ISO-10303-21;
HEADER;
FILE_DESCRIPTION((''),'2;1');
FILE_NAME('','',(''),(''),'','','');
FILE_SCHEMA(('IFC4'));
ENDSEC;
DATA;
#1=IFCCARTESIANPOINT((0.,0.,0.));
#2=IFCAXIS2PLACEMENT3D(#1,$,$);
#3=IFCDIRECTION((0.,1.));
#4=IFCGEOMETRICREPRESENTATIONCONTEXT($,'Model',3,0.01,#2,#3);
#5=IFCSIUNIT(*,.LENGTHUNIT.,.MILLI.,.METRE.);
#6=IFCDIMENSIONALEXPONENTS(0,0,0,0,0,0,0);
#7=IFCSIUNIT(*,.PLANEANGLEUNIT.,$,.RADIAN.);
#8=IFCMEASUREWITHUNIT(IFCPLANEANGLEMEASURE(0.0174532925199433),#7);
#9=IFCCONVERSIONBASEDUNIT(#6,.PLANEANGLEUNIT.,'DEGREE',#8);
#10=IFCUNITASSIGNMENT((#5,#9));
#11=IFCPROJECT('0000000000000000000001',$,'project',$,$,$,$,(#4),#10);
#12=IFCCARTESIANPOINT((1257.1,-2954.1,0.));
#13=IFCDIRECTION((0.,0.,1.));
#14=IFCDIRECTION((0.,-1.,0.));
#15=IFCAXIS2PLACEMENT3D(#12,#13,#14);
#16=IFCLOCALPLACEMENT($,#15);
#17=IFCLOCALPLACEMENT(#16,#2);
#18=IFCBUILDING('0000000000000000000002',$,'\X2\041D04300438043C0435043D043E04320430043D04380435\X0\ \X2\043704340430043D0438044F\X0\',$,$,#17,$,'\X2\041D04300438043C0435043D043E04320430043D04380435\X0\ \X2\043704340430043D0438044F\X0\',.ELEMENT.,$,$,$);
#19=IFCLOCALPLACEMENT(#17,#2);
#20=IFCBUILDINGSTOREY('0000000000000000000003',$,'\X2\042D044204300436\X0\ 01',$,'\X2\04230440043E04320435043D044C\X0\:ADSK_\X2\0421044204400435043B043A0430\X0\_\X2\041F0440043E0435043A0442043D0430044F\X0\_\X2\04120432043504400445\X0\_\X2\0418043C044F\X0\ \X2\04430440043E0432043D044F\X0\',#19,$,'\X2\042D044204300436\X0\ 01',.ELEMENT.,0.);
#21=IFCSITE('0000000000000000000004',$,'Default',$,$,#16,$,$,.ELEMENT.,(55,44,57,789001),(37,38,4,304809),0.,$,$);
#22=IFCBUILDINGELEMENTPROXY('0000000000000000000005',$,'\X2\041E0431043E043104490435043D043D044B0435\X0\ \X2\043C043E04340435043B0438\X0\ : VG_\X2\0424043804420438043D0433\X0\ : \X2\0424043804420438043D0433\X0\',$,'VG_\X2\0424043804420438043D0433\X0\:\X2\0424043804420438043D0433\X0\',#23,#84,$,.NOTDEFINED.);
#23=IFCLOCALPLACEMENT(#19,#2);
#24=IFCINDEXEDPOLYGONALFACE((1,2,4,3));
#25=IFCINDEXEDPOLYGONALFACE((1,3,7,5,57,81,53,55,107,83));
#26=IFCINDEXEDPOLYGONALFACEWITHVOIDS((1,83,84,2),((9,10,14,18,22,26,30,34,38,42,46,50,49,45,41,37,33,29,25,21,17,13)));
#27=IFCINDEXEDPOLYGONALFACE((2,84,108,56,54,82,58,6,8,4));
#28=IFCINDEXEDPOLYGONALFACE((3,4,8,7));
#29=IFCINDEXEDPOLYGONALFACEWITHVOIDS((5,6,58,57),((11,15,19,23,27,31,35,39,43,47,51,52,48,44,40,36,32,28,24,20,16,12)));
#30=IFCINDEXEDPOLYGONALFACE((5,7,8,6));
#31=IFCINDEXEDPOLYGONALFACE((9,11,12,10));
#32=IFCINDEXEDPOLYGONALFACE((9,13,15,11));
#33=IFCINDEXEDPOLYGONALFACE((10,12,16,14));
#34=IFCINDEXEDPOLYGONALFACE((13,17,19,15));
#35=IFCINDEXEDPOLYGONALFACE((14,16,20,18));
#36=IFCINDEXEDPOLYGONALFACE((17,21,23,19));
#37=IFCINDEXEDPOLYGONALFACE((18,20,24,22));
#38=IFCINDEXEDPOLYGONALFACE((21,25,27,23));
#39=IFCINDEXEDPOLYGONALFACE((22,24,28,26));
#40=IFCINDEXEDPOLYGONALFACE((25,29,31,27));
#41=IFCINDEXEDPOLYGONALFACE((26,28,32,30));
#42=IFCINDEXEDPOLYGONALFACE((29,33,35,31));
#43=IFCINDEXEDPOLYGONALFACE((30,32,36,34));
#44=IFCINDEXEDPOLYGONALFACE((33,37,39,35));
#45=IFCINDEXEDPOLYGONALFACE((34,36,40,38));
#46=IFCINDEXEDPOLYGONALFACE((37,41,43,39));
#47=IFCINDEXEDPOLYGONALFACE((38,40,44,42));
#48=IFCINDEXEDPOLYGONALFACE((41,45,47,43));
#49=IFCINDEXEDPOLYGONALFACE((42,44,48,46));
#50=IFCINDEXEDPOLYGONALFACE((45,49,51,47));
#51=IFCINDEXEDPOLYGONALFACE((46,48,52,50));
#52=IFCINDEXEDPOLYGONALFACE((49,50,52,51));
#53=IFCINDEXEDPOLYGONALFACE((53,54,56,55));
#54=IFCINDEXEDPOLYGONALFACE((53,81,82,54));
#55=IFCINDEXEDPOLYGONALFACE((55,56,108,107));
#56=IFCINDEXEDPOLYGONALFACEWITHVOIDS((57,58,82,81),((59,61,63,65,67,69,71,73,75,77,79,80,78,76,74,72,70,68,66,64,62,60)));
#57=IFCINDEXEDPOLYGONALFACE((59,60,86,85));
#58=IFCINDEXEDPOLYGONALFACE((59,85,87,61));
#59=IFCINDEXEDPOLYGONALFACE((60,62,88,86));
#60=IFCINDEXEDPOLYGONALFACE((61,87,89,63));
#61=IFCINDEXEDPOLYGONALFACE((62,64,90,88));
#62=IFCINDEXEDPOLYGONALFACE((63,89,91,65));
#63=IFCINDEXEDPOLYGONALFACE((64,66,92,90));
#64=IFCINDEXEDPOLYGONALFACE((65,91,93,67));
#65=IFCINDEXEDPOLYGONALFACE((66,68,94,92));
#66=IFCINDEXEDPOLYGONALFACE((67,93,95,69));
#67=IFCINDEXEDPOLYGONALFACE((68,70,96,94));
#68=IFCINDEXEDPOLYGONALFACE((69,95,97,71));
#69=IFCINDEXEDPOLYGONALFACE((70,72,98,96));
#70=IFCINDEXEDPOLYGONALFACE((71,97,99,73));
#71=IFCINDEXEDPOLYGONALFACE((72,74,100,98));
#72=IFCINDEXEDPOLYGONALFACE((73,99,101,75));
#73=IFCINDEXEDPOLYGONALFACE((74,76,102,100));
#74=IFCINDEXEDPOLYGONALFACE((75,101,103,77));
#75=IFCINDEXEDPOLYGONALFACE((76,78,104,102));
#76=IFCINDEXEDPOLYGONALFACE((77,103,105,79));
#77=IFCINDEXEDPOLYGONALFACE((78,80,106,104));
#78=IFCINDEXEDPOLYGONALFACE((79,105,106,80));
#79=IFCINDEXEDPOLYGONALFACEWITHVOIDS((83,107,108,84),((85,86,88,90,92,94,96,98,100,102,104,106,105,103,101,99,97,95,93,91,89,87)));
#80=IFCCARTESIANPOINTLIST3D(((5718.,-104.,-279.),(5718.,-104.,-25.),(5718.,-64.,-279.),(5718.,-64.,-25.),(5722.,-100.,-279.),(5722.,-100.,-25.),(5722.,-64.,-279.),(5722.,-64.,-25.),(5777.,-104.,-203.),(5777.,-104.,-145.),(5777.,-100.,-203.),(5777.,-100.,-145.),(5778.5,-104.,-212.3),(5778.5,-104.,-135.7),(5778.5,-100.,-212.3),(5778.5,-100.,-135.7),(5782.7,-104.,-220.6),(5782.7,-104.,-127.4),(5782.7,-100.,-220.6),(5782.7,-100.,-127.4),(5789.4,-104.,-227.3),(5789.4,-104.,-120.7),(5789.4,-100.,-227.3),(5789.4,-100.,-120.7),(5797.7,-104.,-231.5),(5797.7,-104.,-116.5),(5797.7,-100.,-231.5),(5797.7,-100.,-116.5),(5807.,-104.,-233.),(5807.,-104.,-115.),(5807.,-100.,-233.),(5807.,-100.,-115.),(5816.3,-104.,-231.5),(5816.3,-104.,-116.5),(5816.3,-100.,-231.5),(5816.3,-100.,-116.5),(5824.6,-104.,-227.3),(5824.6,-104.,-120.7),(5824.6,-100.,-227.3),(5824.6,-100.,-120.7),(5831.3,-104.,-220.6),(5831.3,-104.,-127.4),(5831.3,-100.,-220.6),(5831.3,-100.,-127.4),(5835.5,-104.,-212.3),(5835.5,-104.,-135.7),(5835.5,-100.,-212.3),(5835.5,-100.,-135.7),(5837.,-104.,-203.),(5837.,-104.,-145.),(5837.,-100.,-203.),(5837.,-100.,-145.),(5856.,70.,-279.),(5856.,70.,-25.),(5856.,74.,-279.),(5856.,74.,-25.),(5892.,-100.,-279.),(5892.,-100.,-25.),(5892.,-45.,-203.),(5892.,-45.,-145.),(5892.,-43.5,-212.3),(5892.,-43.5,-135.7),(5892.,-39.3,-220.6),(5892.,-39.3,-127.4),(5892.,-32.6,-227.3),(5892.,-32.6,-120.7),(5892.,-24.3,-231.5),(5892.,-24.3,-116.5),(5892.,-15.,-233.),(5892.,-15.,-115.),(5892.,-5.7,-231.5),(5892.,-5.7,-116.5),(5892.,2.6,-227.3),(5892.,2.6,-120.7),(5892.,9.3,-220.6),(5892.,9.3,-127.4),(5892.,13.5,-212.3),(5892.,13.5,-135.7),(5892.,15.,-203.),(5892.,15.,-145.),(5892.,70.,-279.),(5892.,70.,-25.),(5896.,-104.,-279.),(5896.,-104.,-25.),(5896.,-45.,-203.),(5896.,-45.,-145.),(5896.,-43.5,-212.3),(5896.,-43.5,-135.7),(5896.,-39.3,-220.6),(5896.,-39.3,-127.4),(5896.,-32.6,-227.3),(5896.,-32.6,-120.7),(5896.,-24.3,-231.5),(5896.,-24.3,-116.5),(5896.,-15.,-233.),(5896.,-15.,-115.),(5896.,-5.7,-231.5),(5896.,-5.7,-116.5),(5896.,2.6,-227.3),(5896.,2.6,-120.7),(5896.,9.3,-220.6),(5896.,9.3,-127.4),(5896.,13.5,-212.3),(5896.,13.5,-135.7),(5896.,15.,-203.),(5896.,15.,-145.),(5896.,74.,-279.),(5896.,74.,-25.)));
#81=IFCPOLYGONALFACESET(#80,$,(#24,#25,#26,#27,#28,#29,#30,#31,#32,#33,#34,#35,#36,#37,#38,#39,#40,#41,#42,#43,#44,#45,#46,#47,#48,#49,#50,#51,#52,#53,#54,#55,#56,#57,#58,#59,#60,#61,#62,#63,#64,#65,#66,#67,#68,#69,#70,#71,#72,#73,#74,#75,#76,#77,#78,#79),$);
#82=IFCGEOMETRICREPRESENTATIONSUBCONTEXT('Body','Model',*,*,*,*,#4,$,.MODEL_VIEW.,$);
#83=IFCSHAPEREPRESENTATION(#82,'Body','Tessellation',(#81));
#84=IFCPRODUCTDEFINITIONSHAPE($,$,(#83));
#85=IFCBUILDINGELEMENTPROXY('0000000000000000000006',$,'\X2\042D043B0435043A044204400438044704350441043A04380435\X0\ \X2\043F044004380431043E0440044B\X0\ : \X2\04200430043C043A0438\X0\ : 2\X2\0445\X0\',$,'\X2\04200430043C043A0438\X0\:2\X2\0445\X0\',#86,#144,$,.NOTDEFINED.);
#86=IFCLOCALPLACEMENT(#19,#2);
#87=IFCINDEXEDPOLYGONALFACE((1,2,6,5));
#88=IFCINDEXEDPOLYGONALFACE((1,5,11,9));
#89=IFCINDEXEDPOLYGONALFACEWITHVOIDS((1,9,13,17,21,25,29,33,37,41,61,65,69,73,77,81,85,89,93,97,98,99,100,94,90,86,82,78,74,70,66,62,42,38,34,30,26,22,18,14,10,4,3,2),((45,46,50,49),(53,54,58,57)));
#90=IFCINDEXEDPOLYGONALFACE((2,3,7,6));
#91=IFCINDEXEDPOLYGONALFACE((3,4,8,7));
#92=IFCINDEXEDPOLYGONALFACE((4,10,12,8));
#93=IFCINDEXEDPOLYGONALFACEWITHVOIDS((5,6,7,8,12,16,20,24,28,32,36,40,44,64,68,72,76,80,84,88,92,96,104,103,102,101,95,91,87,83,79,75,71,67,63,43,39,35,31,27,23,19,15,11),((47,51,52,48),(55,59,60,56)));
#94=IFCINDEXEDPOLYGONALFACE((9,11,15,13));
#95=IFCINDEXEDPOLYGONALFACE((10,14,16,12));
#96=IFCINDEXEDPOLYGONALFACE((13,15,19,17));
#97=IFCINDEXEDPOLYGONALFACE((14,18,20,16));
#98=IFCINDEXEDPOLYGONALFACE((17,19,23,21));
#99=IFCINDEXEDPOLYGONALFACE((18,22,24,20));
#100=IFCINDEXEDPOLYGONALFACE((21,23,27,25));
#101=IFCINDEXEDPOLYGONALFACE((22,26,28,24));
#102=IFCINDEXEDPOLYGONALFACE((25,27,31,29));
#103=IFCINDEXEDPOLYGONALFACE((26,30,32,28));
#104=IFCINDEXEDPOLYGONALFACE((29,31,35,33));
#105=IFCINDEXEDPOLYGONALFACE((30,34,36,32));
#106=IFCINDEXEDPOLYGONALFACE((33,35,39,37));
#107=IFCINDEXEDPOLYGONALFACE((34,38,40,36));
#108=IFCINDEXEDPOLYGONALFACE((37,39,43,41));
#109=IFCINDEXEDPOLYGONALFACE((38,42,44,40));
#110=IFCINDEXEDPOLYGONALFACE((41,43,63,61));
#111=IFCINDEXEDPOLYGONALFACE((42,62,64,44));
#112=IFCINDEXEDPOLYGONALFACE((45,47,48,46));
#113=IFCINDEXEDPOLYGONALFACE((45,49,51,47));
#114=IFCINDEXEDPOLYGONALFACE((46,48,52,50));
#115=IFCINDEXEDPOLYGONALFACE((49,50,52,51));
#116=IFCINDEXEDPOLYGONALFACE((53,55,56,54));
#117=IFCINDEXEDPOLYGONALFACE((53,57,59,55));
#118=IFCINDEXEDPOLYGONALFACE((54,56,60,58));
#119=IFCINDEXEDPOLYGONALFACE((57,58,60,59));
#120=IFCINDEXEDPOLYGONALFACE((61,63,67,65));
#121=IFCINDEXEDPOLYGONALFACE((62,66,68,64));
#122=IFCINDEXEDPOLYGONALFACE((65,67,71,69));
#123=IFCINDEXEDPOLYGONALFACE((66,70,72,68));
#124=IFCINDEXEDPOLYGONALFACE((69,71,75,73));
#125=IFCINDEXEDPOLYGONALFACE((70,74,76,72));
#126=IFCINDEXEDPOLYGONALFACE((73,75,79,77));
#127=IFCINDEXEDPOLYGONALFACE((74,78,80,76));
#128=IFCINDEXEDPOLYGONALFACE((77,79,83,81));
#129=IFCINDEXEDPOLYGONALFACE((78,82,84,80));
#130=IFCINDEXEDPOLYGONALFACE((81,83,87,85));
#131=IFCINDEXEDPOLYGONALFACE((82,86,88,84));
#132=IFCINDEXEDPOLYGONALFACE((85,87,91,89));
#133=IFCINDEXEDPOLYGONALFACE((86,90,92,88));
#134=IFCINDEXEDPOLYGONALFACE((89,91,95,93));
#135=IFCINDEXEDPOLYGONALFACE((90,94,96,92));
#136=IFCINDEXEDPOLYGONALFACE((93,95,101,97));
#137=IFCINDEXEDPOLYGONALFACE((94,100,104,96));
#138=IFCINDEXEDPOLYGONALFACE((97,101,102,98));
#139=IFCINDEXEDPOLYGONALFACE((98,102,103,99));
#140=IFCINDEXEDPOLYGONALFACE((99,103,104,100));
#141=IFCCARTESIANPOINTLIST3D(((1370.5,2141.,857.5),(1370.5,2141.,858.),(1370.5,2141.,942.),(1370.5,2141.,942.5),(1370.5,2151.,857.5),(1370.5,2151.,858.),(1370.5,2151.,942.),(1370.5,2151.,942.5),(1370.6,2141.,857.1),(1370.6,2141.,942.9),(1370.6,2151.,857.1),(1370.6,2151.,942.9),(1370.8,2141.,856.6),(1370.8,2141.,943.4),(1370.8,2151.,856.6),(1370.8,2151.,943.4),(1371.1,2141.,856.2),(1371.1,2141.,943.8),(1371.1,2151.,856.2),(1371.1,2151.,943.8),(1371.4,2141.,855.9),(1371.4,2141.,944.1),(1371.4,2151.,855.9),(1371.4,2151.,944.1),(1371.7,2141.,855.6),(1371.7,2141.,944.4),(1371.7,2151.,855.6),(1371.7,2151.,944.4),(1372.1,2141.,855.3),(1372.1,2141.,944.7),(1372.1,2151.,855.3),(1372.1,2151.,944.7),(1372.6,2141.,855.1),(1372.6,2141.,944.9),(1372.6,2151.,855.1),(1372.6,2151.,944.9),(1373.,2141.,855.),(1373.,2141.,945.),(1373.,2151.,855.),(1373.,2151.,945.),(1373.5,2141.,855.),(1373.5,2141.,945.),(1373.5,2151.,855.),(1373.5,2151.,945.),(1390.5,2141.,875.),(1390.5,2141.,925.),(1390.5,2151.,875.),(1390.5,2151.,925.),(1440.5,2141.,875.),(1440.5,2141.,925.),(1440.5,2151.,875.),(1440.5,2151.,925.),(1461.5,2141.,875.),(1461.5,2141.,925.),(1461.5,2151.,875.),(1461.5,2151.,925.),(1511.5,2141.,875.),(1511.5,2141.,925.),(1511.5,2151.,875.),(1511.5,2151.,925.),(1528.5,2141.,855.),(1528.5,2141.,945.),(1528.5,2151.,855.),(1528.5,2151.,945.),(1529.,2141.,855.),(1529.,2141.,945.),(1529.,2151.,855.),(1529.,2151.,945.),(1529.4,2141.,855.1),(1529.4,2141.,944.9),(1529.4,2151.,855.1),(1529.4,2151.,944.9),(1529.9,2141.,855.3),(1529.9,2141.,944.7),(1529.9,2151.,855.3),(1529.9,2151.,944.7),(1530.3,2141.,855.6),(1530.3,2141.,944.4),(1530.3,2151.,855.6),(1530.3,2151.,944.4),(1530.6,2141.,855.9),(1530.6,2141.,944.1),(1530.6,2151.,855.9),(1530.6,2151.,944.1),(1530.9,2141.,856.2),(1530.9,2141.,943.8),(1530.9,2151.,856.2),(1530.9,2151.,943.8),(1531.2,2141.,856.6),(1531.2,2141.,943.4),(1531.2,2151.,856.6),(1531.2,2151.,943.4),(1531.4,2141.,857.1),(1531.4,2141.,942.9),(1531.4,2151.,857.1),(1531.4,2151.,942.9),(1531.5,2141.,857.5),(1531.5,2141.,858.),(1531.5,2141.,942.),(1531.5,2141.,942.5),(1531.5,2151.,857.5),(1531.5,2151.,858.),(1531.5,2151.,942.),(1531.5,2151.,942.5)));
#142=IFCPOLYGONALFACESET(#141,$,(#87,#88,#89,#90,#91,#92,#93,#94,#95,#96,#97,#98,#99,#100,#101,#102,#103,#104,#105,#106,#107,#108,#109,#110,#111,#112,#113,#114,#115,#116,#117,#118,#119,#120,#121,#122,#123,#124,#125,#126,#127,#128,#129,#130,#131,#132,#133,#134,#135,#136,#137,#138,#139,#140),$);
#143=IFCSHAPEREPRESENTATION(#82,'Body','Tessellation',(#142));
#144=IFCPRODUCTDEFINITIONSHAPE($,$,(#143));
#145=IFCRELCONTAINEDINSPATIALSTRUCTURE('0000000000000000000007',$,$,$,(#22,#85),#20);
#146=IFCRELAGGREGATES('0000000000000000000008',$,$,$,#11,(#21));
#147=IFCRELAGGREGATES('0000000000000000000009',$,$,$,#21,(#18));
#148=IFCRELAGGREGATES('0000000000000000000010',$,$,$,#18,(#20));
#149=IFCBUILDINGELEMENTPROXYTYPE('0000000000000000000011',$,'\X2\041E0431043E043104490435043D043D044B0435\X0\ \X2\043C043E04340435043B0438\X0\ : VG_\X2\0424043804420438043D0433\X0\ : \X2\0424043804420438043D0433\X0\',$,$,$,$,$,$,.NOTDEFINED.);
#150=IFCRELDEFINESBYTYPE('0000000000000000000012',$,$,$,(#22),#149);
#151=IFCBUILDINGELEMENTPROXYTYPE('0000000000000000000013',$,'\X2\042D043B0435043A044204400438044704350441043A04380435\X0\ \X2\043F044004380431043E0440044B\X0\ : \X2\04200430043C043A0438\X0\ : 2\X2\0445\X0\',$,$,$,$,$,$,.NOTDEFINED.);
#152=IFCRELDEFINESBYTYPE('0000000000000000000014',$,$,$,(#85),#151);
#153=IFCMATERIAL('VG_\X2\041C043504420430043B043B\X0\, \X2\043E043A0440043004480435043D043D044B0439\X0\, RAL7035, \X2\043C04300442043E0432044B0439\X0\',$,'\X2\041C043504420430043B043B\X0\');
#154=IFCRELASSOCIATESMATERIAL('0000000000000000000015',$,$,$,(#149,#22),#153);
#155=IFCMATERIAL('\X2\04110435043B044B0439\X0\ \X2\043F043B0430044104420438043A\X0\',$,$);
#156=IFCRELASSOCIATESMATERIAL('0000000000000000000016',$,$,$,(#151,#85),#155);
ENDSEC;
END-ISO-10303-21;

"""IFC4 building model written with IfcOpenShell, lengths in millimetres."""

from ifc_helpers import new_model, entity, si_unit, converted_unit, direction, frame, origin, place, context, subcontext, project, spatial, indexed_curve, outline, extrude, source, transform, mapped, material, type_object, type_shapes, element, save


model = new_model("IFC4")

# Units and contexts
model_context = context("Model", 3, precision=0.01, world=origin(), true_north=direction((0.0, 1.0)))
body_context = subcontext(model_context, "Body", "Model", "MODEL_VIEW")
ifc_project = project(units=[si_unit("LENGTHUNIT", "METRE", prefix="MILLI"), converted_unit("PLANEANGLEUNIT", "DEGREE", entity("IfcPlaneAngleMeasure", 0.0174532925199433), si_unit("PLANEANGLEUNIT", "RADIAN"), dimensions=[0, 0, 0, 0, 0, 0, 0])], contexts=[model_context])

# Site, building, storey
site_placement = place(None, frame((1257.1, -2954.1, 0.0), z_axis=(0.0, 0.0, 1.0), x_axis=(0.0, -1.0, 0.0)))
site = spatial("IfcSite", under=ifc_project, at=site_placement, Name="Default", CompositionType="ELEMENT", RefLatitude=(55, 44, 57, 789001), RefLongitude=(37, 38, 4, 304809), RefElevation=0.0)
building_placement = place(site_placement, origin())
building = spatial("IfcBuilding", under=site, at=building_placement, Name="Наименование здания", LongName="Наименование здания", CompositionType="ELEMENT")
storey_placement = place(building_placement, origin())
storey = spatial("IfcBuildingStorey", under=building, at=storey_placement, Name="Этаж 01", ObjectType="Уровень:ADSK_Стрелка_Проектная_Вверх_Имя уровня", LongName="Этаж 01", CompositionType="ELEMENT", Elevation=0.0)

# Building element proxy, openings
ifc_material_1 = material(Name="VG_Металл, окрашенный, RAL7035, матовый", Category="Металл")
building_element_proxy_type_1 = type_object("IfcBuildingElementProxyType", Name="Обобщенные модели : VG_Фитинг : Фитинг", PredefinedType="NOTDEFINED", material=ifc_material_1)
shared_shape_1 = source(origin(), body_context, "Body", "SweptSolid", [
    extrude(outline(indexed_curve([(-79.2, -79.2), (98.8, -79.2), (98.8, -39.2), (94.8, -39.2), (94.8, -75.2), (-75.2, -75.2), (-75.2, 94.8), (-39.2, 94.8), (-39.2, 98.8), (-79.2, 98.8), (-79.2, -79.2)], self_intersect=False)), frame((-9.8, -9.8, -279.0)), (0.0, 0.0, 1.0), 254.0),
])
type_shapes(building_element_proxy_type_1, [shared_shape_1])
proxy_1_placement = place(storey_placement, frame((5807.0, -15.0, 0.0), z_axis=(0.0, 0.0, 1.0), x_axis=(0.0, 1.0, 0.0)))
proxy_1 = element("IfcBuildingElementProxy", 1, at=proxy_1_placement, inside=storey, type_object=building_element_proxy_type_1, material=ifc_material_1, Name="Обобщенные модели : VG_Фитинг : Фитинг", ObjectType="VG_Фитинг:Фитинг", PredefinedType="NOTDEFINED", context=body_context, shape_type="MappedRepresentation", body=[
    mapped(shared_shape_1, transform((0.0, 0.0, 0.0), scale=1.0)),
])
opening_1_placement = place(storey_placement, frame((5807.0, -15.0, 0.0), z_axis=(0.0, 0.0, 1.0), x_axis=(-1.0, 0.0, 0.0)))
element("IfcOpeningElement", 2, at=opening_1_placement, cuts=proxy_1, PredefinedType="OPENING", context=body_context, shape_type="SweptSolid", body=[
    extrude(outline(indexed_curve([(-30.0, -29.0), (-28.5, -38.3), (-24.3, -46.6), (-17.6, -53.3), (-9.3, -57.5), (0.0, -59.0), (9.3, -57.5), (17.6, -53.3), (24.3, -46.6), (28.5, -38.3), (30.0, -29.0), (30.0, 29.0), (28.5, 38.3), (24.3, 46.6), (17.6, 53.3), (9.3, 57.5), (0.0, 59.0), (-9.3, 57.5), (-17.6, 53.3), (-24.3, 46.6), (-28.5, 38.3), (-30.0, 29.0), (-30.0, -29.0)], self_intersect=False)), frame((0.0, 89.0, -174.0), z_axis=(0.0, -1.0, 0.0), x_axis=(-1.0, 0.0, 0.0)), (0.0, 0.0, 1.0), 4.0),
])
opening_2_placement = place(storey_placement, frame((5807.0, -15.0, 0.0), z_axis=(0.0, 0.0, 1.0), x_axis=(-1.0, 0.0, 0.0)))
element("IfcOpeningElement", 3, at=opening_2_placement, cuts=proxy_1, PredefinedType="OPENING", context=body_context, shape_type="SweptSolid", body=[
    extrude(outline(indexed_curve([(-30.0, -29.0), (-28.5, -38.3), (-24.3, -46.6), (-17.6, -53.3), (-9.3, -57.5), (0.0, -59.0), (9.3, -57.5), (17.6, -53.3), (24.3, -46.6), (28.5, -38.3), (30.0, -29.0), (30.0, 29.0), (28.5, 38.3), (24.3, 46.6), (17.6, 53.3), (9.3, 57.5), (0.0, 59.0), (-9.3, 57.5), (-17.6, 53.3), (-24.3, 46.6), (-28.5, 38.3), (-30.0, 29.0), (-30.0, -29.0)], self_intersect=False)), frame((-89.0, 0.0, -174.0), z_axis=(1.0, 0.0, 0.0), x_axis=(0.0, -1.0, 0.0)), (0.0, 0.0, 1.0), 4.0),
])

# Building element proxy
ifc_material_2 = material(Name="Белый пластик")
building_element_proxy_type_2 = type_object("IfcBuildingElementProxyType", Name="Электрические приборы : Рамки : 2х", PredefinedType="NOTDEFINED", material=ifc_material_2)
shared_shape_2 = source(origin(), body_context, "Body", "SweptSolid", [
    extrude(outline(indexed_curve([(-77.5, 45.0), (-78.0, 45.0), (-78.4, 44.9), (-78.9, 44.7), (-79.3, 44.4), (-79.6, 44.1), (-79.9, 43.8), (-80.2, 43.4), (-80.4, 42.9), (-80.5, 42.5), (-80.5, 42.0), (-80.5, -42.0), (-80.5, -42.5), (-80.4, -42.9), (-80.2, -43.4), (-79.9, -43.8), (-79.6, -44.1), (-79.3, -44.4), (-78.9, -44.7), (-78.4, -44.9), (-78.0, -45.0), (-77.5, -45.0), (77.5, -45.0), (78.0, -45.0), (78.4, -44.9), (78.9, -44.7), (79.3, -44.4), (79.6, -44.1), (79.9, -43.8), (80.2, -43.4), (80.4, -42.9), (80.5, -42.5), (80.5, -42.0), (80.5, 42.0), (80.5, 42.5), (80.4, 42.9), (80.2, 43.4), (79.9, 43.8), (79.6, 44.1), (79.3, 44.4), (78.9, 44.7), (78.4, 44.9), (78.0, 45.0), (77.5, 45.0), (-77.5, 45.0)], self_intersect=False), holes=[indexed_curve([(-60.5, 25.0), (-10.5, 25.0), (-10.5, -25.0), (-60.5, -25.0), (-60.5, 25.0)], self_intersect=False), indexed_curve([(10.5, 25.0), (60.5, 25.0), (60.5, -25.0), (10.5, -25.0), (10.5, 25.0)], self_intersect=False)]), frame((35.5, 0.0, 0.0)), (0.0, 0.0, 1.0), 10.0),
])
type_shapes(building_element_proxy_type_2, [shared_shape_2])
for number, where, z_axis, x_axis, name in (
    (4, (1415.5, 2151.0, 900.0), (0.0, -1.0, 0.0), (1.0, 0.0, 0.0), "Электрические приборы : Рамки : 2х"),
):
    element("IfcBuildingElementProxy", number, at=place(storey_placement, frame(where, z_axis=z_axis, x_axis=x_axis)), inside=storey, type_object=building_element_proxy_type_2, material=ifc_material_2, Name=name, ObjectType="Рамки:2х", PredefinedType="NOTDEFINED", context=body_context, shape_type="MappedRepresentation", body=[
        mapped(shared_shape_2, transform((0.0, 0.0, 0.0), scale=1.0)),
    ])

save(model, "model.ifc")
